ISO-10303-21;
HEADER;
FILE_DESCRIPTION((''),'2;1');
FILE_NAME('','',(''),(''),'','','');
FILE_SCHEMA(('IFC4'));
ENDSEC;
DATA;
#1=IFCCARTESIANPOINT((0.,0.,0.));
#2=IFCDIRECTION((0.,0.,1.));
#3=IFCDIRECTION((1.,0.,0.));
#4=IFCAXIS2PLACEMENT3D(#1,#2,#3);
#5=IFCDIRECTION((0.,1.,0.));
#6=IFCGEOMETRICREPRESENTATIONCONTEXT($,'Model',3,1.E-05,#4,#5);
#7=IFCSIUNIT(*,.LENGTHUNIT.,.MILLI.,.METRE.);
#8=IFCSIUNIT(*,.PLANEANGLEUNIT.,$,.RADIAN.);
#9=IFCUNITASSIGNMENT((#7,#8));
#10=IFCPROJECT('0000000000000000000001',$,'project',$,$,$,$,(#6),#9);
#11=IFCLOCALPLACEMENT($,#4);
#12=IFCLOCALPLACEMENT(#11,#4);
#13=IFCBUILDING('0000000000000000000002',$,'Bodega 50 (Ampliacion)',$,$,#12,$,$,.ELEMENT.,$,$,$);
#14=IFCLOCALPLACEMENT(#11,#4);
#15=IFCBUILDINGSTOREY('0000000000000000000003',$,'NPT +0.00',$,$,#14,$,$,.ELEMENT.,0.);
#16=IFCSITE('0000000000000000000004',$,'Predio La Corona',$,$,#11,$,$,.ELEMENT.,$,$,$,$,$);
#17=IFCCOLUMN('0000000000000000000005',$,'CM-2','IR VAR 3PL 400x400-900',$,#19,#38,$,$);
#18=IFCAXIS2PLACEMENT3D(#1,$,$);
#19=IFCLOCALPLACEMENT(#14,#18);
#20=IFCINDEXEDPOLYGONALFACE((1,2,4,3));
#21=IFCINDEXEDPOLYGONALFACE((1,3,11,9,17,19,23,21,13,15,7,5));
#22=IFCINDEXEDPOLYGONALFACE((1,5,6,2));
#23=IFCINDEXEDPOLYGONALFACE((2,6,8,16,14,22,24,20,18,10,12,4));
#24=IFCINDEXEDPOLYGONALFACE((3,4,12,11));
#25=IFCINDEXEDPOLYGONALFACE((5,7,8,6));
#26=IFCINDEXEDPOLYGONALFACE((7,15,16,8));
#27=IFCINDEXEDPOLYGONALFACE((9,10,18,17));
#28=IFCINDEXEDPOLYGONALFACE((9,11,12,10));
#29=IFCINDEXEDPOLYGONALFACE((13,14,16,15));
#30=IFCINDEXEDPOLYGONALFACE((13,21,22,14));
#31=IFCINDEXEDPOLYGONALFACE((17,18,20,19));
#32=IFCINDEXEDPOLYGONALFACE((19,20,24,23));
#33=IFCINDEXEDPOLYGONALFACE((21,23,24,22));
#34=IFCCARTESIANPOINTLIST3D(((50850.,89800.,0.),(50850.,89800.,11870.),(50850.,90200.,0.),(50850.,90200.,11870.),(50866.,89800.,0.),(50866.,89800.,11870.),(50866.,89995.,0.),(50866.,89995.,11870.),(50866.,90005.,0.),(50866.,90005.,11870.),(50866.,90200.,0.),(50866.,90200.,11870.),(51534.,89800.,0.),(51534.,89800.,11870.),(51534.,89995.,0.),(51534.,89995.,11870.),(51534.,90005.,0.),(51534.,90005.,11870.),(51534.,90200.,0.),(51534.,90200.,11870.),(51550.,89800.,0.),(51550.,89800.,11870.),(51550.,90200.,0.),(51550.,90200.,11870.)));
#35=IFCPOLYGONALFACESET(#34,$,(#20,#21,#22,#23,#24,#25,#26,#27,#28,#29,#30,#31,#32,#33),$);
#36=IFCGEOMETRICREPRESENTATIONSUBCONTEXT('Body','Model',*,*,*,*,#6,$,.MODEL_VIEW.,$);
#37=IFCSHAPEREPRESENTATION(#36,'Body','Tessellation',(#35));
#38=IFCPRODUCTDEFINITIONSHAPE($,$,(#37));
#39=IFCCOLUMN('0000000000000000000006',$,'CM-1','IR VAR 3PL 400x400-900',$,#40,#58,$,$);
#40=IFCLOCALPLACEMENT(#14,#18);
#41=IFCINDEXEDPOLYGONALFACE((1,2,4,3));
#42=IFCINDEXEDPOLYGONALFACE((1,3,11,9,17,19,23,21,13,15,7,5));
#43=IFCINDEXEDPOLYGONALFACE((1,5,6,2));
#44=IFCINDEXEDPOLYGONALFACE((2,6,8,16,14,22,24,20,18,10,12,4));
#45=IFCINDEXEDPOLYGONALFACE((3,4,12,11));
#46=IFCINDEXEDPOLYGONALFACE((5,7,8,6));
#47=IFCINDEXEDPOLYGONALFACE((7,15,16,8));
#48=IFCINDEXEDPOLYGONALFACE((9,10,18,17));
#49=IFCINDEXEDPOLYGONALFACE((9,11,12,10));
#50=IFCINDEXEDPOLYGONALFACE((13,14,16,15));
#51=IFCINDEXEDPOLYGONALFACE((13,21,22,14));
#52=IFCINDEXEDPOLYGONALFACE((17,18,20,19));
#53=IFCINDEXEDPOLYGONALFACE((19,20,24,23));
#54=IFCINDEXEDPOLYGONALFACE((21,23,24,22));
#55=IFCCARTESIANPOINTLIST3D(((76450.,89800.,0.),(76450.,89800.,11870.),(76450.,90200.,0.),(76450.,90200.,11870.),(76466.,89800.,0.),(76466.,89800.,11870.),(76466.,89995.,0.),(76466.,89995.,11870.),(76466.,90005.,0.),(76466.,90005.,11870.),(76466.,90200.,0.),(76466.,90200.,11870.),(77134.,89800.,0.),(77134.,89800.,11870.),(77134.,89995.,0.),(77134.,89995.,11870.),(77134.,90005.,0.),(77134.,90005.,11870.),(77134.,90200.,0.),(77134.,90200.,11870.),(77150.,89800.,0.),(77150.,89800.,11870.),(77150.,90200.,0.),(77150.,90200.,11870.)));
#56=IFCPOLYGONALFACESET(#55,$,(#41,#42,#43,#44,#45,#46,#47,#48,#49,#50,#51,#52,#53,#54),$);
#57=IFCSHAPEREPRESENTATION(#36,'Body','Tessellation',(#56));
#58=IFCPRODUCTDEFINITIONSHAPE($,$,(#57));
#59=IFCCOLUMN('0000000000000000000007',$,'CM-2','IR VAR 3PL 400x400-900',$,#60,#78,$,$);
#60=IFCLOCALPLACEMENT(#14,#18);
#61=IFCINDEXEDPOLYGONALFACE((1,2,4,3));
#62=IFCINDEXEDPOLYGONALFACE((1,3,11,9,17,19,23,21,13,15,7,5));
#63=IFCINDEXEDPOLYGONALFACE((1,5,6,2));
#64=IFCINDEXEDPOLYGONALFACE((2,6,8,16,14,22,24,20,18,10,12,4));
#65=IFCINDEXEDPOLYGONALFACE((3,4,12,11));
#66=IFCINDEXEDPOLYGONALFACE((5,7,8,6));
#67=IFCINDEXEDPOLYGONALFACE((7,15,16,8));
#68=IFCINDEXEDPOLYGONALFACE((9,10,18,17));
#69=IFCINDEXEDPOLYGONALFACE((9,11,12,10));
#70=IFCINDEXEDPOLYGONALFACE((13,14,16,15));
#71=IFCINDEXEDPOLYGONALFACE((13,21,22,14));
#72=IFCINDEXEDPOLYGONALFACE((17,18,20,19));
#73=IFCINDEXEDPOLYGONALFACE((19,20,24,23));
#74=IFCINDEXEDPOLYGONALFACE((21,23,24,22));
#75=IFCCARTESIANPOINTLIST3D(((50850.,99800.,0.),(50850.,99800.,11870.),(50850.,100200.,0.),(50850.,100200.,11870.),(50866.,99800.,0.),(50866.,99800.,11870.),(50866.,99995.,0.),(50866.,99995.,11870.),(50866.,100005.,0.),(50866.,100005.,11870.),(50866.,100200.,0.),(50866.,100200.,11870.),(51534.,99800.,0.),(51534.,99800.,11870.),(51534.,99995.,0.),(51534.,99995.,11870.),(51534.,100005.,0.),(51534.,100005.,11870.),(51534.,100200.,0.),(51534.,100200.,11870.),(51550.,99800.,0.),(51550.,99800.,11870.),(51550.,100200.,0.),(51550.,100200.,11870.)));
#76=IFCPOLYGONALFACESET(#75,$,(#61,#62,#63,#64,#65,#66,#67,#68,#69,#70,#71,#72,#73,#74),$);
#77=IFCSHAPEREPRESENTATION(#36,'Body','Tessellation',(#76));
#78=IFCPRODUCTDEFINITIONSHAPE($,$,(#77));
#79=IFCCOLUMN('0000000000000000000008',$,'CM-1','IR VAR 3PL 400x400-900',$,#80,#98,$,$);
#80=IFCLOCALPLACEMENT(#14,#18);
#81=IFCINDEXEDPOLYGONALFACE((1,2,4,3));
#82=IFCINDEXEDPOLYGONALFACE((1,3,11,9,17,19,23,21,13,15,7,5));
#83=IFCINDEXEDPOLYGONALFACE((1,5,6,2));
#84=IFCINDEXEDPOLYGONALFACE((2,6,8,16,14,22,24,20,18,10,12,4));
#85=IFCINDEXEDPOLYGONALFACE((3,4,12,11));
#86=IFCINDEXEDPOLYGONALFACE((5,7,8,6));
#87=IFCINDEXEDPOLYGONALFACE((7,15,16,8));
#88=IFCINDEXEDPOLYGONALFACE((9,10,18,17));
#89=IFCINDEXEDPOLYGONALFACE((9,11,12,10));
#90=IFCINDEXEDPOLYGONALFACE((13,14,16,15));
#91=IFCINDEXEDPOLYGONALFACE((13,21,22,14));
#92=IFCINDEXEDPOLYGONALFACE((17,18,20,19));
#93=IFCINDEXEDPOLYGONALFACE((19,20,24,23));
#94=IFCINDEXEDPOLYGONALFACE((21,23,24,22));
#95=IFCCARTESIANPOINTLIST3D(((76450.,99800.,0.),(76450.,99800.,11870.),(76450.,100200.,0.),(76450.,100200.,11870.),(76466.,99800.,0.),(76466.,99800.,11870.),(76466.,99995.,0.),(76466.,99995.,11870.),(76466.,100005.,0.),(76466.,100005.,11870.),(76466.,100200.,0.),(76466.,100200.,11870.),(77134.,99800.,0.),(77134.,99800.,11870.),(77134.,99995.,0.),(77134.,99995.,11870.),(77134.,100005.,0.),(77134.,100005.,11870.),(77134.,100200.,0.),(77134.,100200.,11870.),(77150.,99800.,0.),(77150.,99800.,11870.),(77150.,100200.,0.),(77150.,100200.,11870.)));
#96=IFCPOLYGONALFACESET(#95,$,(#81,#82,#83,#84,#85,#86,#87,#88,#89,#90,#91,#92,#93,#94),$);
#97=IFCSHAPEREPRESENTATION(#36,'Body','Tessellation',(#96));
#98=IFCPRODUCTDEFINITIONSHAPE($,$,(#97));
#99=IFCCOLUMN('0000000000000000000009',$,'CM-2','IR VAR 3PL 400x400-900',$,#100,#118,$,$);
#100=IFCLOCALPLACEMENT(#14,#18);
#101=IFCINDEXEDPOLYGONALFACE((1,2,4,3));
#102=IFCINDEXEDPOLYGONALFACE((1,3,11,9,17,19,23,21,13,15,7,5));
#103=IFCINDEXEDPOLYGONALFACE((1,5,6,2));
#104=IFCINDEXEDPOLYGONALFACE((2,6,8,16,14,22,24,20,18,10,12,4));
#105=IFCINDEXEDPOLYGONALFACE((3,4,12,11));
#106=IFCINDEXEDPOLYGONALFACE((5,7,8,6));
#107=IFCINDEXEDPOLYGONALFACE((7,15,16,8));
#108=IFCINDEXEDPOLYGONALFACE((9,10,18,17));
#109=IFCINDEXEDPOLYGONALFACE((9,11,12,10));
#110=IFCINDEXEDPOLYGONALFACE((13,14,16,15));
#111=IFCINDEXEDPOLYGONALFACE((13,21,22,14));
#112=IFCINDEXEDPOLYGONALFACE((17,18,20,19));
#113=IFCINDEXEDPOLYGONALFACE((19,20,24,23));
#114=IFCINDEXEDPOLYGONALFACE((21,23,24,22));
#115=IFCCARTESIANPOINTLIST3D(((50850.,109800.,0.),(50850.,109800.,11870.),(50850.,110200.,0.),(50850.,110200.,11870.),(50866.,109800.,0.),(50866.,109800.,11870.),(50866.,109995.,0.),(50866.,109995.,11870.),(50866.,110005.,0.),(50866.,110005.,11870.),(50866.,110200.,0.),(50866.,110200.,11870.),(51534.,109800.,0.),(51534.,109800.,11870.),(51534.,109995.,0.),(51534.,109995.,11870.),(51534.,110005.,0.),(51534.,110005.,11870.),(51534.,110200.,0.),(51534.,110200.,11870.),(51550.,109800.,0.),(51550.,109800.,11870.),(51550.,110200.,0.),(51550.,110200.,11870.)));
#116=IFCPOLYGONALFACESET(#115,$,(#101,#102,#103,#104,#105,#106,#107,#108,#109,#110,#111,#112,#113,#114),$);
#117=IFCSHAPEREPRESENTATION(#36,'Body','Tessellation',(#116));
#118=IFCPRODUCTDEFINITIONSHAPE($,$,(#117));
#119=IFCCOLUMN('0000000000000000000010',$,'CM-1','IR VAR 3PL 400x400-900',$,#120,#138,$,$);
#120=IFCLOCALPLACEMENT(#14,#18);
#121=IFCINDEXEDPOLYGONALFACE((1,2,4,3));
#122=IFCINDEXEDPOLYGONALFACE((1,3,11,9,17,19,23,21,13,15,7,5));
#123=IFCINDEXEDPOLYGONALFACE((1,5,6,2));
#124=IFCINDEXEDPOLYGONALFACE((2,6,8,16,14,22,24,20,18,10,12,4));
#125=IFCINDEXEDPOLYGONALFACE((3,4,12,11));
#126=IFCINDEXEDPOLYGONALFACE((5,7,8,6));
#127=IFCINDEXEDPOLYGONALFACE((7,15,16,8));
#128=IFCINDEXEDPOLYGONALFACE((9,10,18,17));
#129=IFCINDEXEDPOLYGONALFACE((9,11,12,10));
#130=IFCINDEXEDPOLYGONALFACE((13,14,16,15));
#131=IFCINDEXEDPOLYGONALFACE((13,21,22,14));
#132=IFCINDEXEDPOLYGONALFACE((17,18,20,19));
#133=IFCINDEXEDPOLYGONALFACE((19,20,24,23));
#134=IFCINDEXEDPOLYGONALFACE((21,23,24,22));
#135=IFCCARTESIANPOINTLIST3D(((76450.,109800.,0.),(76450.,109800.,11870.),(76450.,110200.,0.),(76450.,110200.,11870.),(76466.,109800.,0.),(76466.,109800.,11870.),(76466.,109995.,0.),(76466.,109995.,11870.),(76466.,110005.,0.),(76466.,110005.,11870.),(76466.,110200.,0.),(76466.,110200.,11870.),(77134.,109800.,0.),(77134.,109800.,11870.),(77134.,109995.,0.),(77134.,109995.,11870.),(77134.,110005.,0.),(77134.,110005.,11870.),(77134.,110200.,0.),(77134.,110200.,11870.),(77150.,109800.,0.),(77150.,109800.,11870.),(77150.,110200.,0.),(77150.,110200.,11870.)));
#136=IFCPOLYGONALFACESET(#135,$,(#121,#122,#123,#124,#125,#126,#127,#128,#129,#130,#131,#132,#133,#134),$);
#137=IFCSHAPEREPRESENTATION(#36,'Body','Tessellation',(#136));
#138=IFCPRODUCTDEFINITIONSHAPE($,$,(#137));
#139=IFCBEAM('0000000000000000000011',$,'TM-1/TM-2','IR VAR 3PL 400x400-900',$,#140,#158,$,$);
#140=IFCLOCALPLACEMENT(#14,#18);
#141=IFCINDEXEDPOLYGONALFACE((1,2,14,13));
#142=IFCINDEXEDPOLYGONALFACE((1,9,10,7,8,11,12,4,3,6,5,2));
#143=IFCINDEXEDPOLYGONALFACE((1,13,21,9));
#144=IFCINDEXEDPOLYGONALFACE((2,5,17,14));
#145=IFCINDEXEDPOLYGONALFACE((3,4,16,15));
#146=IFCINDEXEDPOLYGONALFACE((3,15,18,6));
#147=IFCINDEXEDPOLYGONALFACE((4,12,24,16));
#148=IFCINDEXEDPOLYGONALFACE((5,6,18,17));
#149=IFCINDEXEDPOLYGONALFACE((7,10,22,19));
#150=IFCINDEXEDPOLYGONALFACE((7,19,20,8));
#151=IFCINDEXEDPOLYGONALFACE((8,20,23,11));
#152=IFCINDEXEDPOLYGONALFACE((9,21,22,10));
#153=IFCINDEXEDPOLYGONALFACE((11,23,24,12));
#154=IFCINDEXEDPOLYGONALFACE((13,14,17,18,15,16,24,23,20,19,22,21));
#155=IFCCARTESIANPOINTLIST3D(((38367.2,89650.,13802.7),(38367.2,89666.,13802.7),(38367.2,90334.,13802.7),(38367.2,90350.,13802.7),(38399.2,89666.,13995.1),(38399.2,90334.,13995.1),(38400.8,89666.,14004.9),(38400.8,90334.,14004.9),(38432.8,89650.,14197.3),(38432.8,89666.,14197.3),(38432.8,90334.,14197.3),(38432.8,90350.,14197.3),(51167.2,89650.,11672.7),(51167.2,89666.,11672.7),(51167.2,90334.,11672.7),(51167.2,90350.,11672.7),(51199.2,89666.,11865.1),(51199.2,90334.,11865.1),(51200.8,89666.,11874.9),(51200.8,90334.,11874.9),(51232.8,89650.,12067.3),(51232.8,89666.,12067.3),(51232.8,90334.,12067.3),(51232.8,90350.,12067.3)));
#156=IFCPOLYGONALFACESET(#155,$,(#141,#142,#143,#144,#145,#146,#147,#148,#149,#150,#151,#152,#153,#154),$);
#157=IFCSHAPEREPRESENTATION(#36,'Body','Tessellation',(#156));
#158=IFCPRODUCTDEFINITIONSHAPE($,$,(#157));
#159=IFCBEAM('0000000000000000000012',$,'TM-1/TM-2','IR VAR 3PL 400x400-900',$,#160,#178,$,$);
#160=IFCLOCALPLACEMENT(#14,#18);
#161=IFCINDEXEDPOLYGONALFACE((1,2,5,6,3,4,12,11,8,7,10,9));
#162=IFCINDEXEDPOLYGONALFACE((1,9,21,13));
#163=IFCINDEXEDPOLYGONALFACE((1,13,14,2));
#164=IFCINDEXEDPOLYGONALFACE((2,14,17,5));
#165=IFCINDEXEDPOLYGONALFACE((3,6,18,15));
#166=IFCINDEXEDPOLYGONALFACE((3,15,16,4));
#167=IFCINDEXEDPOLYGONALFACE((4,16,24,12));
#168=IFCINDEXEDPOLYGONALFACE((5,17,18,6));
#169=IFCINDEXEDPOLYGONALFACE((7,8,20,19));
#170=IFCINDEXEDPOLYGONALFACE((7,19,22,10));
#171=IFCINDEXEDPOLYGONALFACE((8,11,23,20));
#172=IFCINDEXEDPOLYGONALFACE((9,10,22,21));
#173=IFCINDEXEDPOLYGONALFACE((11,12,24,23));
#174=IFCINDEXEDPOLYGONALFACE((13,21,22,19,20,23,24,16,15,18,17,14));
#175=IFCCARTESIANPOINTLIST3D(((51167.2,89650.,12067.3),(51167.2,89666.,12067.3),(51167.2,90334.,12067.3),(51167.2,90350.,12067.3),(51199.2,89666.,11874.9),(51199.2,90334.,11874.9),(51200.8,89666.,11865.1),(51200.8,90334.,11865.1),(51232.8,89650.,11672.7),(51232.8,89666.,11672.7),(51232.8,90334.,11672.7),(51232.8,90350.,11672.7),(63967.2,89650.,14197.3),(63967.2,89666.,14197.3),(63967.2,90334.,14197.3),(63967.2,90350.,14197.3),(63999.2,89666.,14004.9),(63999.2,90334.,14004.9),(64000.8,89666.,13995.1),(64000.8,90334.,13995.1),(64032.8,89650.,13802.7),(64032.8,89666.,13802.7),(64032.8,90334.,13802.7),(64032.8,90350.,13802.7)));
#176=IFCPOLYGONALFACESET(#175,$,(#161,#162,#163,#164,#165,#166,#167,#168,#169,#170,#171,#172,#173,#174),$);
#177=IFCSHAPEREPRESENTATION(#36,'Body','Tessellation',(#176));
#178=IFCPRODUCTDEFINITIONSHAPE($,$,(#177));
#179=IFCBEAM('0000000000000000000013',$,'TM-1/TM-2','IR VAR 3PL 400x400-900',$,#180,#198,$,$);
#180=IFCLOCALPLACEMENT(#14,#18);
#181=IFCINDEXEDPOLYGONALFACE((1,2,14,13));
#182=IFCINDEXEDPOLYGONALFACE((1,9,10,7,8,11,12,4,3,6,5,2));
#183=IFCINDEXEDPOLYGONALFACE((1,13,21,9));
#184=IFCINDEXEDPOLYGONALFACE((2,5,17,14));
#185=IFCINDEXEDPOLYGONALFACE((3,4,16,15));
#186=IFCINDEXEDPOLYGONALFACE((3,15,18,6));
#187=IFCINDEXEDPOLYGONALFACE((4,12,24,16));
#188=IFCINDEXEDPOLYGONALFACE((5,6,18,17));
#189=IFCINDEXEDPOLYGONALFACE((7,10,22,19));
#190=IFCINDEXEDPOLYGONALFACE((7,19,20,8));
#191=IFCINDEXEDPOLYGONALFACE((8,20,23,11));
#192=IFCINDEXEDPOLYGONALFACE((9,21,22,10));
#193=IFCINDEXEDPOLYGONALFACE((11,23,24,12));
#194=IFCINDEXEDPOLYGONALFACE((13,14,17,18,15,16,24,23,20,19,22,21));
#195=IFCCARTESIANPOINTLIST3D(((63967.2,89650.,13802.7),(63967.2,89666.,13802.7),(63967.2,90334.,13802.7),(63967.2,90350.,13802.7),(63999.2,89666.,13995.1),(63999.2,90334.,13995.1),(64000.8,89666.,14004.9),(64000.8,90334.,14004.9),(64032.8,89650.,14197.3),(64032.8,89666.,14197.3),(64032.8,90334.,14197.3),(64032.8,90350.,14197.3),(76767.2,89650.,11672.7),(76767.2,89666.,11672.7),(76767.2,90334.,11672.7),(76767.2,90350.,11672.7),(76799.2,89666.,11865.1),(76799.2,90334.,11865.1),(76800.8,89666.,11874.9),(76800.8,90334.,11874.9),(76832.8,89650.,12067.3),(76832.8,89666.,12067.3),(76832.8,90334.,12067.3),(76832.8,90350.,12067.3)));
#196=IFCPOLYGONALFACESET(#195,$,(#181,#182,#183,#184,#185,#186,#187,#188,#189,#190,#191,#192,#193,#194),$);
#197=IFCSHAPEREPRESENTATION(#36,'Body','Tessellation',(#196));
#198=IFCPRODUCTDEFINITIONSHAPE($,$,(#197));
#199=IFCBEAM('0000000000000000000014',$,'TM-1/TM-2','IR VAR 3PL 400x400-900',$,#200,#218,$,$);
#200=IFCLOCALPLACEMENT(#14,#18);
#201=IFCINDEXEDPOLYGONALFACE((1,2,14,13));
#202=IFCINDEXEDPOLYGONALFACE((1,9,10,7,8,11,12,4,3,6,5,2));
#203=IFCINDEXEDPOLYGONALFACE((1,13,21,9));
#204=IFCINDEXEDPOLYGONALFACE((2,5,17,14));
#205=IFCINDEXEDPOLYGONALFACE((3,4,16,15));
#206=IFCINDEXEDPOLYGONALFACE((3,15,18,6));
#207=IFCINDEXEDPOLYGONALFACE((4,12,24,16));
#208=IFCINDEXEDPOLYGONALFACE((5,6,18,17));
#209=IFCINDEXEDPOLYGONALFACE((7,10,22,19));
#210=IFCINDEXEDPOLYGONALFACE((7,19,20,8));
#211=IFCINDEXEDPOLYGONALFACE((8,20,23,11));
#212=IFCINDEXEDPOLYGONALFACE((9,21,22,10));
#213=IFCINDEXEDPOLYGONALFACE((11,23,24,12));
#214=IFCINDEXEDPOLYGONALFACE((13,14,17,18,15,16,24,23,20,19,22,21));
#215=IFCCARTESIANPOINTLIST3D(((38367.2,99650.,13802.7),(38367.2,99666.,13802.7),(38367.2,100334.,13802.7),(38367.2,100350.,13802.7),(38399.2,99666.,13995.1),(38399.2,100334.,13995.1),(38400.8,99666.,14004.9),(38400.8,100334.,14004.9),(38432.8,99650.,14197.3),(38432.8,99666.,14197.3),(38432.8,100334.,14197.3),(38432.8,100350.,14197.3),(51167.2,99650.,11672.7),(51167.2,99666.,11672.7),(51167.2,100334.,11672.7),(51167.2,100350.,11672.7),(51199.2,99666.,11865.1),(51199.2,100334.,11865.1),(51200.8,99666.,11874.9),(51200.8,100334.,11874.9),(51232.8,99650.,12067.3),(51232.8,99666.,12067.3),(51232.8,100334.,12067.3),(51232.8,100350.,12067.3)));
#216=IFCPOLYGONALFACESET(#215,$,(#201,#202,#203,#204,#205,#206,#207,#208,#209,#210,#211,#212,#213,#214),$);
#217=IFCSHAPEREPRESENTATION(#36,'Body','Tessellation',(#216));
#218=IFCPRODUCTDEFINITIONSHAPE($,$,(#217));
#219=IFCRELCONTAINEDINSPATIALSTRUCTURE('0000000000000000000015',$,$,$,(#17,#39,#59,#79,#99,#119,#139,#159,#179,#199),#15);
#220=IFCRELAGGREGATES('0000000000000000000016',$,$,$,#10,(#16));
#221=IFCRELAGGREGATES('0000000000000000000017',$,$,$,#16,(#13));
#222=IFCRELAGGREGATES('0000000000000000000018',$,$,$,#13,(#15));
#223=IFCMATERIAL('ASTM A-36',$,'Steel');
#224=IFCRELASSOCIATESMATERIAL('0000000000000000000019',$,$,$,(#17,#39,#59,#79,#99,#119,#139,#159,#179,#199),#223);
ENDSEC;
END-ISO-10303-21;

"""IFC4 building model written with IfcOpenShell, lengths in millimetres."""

from ifc_helpers import new_model, si_unit, direction, frame, origin_with_axes, origin_2d, place, context, subcontext, project, spatial, i_section, extrude, material, element, save


model = new_model("IFC4")

# Units and contexts
model_context = context("Model", 3, precision=1e-05, world=origin_with_axes(), true_north=direction((0.0, 1.0, 0.0)))
body_context = subcontext(model_context, "Body", "Model", "MODEL_VIEW")
ifc_project = project(units=[si_unit("LENGTHUNIT", "METRE", prefix="MILLI"), si_unit("PLANEANGLEUNIT", "RADIAN")], contexts=[model_context])

# Site, building, storey
site_placement = place(None, origin_with_axes())
site = spatial("IfcSite", under=ifc_project, at=site_placement, Name="Predio La Corona", CompositionType="ELEMENT")
building_placement = place(site_placement, origin_with_axes())
building = spatial("IfcBuilding", under=site, at=building_placement, Name="Bodega 50 (Ampliacion)", CompositionType="ELEMENT")
storey_placement = place(site_placement, origin_with_axes())
storey = spatial("IfcBuildingStorey", under=building, at=storey_placement, Name="NPT +0.00", CompositionType="ELEMENT", Elevation=0.0)

# Columns
ifc_material = material(Name="ASTM A-36", Category="Steel")
for number, where, z_axis, x_axis, name in (
    (1, (51200.0, 90000.0, 0.0), (0.0, 0.0, 1.0), (0.0, -1.0, 0.0), "CM-2"),
    (2, (76800.0, 90000.0, 0.0), (0.0, 0.0, 1.0), (0.0, -1.0, 0.0), "CM-1"),
    (3, (51200.0, 100000.0, 0.0), (0.0, 0.0, 1.0), (0.0, -1.0, 0.0), "CM-2"),
    (4, (76800.0, 100000.0, 0.0), (0.0, 0.0, 1.0), (0.0, -1.0, 0.0), "CM-1"),
    (5, (51200.0, 110000.0, 0.0), (0.0, 0.0, 1.0), (0.0, -1.0, 0.0), "CM-2"),
    (6, (76800.0, 110000.0, 0.0), (0.0, 0.0, 1.0), (0.0, -1.0, 0.0), "CM-1"),
):
    element("IfcColumn", number, at=place(storey_placement, frame(where, z_axis=z_axis, x_axis=x_axis)), inside=storey, material=ifc_material, Name=name, Description="IR VAR 3PL 400x400-900", context=body_context, shape_type="SweptSolid", body=[
        extrude(i_section(OverallWidth=400.0, OverallDepth=700.0, WebThickness=10.0, FlangeThickness=16.0, at=origin_2d()), origin_with_axes(), (0.0, 0.0, 1.0), 11870.0),
    ])

# Beams
for number, where, z_axis, x_axis, name in (
    (7, (38400.0, 90000.0, 14000.0), (0.986436, 0.0, -0.164149), (-0.164149, 0.0, -0.986436), "TM-1/TM-2"),
    (8, (51200.0, 90000.0, 11870.0), (0.986436, 0.0, 0.164149), (0.164149, 0.0, -0.986436), "TM-1/TM-2"),
    (9, (64000.0, 90000.0, 14000.0), (0.986436, 0.0, -0.164149), (-0.164149, 0.0, -0.986436), "TM-1/TM-2"),
    (10, (38400.0, 100000.0, 14000.0), (0.986436, 0.0, -0.164149), (-0.164149, 0.0, -0.986436), "TM-1/TM-2"),
):
    element("IfcBeam", number, at=place(storey_placement, frame(where, z_axis=z_axis, x_axis=x_axis)), inside=storey, material=ifc_material, Name=name, Description="IR VAR 3PL 400x400-900", context=body_context, shape_type="SweptSolid", body=[
        extrude(i_section(OverallWidth=400.0, OverallDepth=700.0, WebThickness=10.0, FlangeThickness=16.0, at=origin_2d()), origin_with_axes(), (0.0, 0.0, 1.0), 12976.0),
    ])

save(model, "model.ifc")
